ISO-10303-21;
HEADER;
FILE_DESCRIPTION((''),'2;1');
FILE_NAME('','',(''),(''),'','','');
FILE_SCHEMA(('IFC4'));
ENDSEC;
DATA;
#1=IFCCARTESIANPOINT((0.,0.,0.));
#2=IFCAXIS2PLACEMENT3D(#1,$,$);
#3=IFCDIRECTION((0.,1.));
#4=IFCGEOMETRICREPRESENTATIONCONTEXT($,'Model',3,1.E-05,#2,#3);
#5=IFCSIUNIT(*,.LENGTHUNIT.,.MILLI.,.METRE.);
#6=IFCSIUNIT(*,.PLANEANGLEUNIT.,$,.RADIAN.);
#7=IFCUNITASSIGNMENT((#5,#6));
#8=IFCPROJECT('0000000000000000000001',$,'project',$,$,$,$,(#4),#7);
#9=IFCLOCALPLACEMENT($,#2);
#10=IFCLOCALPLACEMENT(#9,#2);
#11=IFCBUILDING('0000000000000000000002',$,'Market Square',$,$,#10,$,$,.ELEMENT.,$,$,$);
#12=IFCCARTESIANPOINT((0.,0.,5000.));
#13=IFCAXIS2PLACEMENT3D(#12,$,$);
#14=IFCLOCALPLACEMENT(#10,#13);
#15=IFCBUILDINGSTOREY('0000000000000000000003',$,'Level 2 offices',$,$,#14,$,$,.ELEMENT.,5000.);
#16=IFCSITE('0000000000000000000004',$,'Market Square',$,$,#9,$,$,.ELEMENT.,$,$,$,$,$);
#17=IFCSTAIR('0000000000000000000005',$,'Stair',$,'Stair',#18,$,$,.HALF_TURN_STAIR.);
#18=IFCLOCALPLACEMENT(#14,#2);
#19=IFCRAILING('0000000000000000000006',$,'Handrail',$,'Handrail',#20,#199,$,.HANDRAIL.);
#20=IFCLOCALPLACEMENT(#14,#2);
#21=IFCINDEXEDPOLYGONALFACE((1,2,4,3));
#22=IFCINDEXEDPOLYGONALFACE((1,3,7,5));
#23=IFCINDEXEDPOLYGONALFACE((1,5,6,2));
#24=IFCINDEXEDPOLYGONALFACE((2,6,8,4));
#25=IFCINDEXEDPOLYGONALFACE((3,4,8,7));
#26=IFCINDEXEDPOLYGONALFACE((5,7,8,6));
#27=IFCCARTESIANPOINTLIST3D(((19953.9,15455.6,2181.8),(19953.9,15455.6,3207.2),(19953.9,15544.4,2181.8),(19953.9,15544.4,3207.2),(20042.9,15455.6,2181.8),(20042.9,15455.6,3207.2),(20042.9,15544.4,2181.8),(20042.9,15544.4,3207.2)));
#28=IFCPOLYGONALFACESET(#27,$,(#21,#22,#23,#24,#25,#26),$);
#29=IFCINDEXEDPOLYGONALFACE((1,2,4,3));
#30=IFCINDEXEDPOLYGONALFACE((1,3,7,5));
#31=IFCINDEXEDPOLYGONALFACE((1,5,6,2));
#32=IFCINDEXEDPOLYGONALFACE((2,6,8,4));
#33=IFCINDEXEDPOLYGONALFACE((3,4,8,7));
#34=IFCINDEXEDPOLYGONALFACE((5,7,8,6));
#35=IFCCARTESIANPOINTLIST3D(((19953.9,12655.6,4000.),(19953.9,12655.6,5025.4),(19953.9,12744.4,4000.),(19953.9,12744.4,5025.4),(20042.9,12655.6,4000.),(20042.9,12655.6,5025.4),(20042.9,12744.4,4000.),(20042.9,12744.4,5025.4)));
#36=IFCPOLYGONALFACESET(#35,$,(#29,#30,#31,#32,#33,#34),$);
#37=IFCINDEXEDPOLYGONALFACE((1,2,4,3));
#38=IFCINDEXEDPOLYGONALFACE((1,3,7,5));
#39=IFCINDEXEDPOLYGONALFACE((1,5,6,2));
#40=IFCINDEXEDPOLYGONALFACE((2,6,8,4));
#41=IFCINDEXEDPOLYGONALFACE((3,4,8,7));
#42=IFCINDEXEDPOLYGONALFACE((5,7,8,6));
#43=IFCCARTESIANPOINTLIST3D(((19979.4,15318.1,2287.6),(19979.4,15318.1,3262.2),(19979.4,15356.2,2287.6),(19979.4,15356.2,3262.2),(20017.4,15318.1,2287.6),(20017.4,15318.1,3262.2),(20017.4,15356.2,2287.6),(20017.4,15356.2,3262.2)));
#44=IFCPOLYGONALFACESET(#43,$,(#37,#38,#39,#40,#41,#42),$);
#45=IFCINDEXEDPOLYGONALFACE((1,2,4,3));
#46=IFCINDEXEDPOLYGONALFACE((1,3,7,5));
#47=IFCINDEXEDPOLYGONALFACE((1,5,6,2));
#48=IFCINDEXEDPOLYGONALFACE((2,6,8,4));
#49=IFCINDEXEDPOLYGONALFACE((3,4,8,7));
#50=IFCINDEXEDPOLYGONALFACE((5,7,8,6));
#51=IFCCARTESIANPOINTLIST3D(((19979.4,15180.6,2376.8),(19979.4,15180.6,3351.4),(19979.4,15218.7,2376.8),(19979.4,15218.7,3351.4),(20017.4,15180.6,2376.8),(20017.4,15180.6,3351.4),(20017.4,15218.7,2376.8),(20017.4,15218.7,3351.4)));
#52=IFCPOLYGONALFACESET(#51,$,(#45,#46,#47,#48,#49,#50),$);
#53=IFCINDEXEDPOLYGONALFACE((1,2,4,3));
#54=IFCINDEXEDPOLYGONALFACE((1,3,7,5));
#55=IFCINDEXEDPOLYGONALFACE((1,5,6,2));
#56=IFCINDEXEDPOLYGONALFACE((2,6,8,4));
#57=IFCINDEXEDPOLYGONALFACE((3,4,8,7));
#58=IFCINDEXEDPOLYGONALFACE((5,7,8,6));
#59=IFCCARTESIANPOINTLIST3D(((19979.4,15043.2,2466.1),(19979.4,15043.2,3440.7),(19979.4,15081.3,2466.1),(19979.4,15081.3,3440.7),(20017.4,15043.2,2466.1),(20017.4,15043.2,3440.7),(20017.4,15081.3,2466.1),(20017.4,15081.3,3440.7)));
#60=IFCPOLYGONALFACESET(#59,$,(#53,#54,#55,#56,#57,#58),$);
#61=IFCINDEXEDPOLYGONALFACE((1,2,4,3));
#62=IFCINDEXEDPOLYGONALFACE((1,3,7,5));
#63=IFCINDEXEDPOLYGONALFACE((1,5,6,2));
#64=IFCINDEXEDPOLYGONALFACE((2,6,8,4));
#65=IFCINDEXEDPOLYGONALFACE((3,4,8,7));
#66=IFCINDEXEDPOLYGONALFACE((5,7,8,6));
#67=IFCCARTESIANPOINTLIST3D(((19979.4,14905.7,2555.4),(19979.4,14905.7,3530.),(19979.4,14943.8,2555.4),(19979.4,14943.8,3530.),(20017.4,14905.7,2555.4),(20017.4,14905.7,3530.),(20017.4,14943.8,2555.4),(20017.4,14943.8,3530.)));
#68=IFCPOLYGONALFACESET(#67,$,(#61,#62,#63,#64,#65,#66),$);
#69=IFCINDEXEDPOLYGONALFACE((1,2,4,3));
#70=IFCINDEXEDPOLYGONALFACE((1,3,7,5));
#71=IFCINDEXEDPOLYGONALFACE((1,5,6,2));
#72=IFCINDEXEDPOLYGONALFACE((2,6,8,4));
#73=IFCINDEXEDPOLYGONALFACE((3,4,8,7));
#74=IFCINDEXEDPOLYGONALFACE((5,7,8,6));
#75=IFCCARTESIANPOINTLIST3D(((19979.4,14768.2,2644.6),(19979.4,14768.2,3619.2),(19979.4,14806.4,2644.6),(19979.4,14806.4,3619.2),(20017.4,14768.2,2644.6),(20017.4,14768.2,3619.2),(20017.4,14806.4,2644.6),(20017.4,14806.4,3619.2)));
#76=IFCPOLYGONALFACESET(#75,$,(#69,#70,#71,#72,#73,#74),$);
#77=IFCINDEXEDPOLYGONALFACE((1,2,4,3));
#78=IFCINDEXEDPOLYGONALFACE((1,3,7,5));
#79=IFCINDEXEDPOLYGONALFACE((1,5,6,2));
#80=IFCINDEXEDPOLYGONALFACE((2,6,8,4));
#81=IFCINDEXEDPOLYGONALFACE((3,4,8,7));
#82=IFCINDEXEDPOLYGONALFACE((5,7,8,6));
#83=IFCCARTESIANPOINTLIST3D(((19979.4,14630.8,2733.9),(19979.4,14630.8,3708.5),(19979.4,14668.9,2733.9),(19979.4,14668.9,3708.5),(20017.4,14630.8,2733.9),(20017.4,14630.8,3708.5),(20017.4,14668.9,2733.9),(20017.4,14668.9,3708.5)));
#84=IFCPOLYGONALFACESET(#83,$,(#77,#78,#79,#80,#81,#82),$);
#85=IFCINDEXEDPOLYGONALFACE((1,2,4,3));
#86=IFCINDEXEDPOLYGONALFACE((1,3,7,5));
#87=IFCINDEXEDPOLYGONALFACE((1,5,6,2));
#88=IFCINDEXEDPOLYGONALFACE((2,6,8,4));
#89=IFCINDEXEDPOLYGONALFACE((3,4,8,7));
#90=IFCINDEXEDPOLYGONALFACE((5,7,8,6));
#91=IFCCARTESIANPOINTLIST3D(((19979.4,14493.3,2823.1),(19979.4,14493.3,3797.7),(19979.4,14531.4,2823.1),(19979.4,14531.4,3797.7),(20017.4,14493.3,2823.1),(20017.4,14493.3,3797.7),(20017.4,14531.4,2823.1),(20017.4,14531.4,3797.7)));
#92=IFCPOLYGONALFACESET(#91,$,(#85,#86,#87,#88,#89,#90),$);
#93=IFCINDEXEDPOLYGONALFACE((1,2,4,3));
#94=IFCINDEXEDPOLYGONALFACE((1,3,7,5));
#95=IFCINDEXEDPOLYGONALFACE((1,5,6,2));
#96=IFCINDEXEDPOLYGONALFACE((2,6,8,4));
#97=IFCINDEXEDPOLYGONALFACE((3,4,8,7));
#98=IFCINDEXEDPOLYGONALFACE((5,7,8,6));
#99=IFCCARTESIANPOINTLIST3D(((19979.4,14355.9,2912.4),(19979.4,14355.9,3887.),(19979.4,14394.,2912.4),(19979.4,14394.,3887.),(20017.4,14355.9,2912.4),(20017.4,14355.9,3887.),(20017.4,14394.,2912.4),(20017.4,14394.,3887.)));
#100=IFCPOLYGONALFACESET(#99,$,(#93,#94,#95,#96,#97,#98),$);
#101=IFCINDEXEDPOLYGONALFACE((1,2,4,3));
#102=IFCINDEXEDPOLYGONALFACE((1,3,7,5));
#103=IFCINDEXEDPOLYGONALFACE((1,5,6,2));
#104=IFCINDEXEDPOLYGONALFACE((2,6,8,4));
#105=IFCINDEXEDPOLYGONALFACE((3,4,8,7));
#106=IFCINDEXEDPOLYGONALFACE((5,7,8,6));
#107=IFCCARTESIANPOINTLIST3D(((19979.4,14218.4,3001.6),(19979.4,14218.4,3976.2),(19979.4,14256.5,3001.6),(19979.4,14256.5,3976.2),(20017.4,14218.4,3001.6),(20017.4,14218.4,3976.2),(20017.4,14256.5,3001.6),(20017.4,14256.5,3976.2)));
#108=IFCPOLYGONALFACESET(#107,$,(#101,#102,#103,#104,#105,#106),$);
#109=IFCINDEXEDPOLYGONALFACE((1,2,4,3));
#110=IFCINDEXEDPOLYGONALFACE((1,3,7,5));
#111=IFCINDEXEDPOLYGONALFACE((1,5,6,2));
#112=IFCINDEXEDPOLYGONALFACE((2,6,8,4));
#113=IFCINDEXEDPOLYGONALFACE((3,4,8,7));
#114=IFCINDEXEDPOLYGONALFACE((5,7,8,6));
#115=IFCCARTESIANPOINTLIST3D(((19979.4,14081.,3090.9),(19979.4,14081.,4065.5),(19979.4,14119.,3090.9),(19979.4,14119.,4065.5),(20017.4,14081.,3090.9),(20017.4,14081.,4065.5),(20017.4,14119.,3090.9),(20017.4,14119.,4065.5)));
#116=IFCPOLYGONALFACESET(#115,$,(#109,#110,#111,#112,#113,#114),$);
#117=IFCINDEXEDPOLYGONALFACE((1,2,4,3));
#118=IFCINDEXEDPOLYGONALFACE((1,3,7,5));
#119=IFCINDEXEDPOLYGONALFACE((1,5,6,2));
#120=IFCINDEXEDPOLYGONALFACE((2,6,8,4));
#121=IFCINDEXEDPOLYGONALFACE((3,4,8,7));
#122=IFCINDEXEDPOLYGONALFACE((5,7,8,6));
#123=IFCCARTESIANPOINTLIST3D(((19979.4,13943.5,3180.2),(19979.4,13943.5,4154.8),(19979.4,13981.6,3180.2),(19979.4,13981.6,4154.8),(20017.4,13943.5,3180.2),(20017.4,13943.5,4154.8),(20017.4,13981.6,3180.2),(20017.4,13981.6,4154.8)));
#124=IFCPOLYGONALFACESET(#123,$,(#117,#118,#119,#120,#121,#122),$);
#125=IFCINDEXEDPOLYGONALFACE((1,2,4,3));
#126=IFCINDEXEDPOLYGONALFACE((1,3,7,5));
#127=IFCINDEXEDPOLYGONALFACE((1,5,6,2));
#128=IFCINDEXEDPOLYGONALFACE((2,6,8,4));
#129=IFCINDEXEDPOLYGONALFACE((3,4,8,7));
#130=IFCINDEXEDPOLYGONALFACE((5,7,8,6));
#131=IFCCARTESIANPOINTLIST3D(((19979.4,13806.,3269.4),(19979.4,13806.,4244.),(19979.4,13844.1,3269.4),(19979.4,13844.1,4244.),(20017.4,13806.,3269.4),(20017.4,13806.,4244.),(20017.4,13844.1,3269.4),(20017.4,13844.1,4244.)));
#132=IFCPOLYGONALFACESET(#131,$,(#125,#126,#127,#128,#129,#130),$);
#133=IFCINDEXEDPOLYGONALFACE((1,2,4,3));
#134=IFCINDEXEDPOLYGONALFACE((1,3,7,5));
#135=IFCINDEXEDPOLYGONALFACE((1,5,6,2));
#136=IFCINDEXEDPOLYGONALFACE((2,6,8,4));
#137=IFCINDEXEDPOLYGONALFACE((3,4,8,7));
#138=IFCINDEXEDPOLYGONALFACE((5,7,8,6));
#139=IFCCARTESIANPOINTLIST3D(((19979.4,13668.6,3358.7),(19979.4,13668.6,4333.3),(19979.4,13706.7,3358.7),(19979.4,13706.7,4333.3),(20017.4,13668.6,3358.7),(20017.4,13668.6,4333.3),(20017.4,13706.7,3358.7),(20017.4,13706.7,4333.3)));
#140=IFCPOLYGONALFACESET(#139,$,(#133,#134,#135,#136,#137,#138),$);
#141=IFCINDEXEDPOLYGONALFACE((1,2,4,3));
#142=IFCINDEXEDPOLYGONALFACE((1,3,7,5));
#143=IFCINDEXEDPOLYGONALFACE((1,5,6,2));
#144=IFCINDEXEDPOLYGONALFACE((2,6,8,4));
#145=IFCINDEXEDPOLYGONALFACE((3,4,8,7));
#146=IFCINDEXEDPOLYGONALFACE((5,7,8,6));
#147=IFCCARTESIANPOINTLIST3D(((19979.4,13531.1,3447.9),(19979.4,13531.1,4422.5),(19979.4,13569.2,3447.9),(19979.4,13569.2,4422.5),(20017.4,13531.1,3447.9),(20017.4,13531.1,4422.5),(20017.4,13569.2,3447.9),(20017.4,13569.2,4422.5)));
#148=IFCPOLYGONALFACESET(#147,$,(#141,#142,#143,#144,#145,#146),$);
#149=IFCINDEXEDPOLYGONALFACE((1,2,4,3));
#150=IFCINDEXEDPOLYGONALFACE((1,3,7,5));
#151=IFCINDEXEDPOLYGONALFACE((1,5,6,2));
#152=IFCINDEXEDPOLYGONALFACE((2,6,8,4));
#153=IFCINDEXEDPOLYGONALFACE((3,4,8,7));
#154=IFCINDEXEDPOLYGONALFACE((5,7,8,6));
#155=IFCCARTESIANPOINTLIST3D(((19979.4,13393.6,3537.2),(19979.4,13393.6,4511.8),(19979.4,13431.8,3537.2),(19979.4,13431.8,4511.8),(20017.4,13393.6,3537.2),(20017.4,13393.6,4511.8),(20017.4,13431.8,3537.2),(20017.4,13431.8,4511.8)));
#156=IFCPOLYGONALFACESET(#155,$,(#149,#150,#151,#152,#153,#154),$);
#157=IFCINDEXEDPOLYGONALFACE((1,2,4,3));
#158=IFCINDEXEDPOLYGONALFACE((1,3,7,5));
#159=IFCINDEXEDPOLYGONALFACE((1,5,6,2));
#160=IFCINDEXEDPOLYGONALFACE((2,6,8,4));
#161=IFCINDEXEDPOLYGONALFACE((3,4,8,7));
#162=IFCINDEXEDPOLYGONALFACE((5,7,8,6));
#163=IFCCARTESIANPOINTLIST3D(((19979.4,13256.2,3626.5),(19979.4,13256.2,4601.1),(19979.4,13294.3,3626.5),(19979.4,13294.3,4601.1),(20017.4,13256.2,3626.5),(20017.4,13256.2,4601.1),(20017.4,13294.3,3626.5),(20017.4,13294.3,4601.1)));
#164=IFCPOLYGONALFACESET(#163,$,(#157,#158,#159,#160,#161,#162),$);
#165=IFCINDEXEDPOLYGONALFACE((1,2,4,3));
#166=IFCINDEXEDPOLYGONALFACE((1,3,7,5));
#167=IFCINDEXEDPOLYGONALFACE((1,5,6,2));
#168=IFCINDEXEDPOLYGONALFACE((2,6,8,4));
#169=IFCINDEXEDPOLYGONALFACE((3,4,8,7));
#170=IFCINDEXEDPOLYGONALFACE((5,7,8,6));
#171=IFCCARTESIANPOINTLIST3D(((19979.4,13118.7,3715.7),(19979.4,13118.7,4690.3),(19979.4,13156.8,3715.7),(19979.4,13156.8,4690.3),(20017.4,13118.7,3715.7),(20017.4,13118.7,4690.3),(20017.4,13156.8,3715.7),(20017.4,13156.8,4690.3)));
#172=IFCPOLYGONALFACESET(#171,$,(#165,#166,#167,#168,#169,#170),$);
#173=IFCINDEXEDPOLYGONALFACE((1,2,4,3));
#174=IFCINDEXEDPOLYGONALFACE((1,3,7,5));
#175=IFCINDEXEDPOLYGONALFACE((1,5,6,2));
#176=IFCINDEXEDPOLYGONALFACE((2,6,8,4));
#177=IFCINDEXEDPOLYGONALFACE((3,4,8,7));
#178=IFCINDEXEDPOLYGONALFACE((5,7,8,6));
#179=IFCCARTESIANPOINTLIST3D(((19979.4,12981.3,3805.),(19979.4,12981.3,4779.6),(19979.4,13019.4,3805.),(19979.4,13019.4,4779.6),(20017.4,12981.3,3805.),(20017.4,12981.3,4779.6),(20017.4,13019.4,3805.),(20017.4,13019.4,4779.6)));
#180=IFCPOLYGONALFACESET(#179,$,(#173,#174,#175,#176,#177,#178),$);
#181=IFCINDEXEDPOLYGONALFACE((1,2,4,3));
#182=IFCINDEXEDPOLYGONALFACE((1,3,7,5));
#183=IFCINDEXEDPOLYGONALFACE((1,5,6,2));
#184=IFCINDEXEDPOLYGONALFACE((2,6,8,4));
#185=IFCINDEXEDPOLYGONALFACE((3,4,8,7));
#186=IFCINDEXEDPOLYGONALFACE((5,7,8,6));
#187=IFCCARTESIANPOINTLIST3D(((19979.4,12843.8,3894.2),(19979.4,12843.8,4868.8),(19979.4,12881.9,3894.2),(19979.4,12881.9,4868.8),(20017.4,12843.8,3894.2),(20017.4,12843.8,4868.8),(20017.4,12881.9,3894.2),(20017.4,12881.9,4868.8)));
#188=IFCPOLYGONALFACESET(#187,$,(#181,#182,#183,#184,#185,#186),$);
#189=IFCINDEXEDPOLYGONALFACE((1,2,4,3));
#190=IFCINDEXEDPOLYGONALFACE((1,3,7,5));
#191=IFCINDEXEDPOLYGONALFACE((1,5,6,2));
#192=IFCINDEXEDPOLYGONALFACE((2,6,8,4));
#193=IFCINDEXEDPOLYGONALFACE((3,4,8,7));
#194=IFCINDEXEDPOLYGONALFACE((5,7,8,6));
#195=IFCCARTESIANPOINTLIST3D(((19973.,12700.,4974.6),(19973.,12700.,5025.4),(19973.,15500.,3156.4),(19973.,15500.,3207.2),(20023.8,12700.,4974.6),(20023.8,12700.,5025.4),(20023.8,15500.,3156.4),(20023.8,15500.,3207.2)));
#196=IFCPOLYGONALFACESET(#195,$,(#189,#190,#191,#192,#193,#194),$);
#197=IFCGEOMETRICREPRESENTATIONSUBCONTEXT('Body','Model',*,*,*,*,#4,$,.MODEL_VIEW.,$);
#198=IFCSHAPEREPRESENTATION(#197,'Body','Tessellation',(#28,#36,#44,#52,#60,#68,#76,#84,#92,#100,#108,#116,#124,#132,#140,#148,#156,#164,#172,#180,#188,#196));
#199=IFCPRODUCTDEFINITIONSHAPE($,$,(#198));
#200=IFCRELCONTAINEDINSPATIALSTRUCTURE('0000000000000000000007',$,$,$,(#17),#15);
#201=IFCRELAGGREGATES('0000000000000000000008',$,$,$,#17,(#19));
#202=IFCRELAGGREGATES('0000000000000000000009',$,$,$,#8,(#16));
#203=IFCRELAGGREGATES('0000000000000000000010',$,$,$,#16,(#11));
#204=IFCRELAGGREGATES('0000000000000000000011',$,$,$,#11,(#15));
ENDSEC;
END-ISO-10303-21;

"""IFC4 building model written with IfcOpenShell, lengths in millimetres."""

from ifc_helpers import new_model, si_unit, direction, frame, origin, origin_with_axes, place, context, subcontext, project, spatial, polyline, outline, extrude, element, aggregate, save


model = new_model("IFC4")

# Units and contexts
model_context = context("Model", 3, precision=1e-05, world=origin(), true_north=direction((0.0, 1.0)))
body_context = subcontext(model_context, "Body", "Model", "MODEL_VIEW")
ifc_project = project(units=[si_unit("LENGTHUNIT", "METRE", prefix="MILLI"), si_unit("PLANEANGLEUNIT", "RADIAN")], contexts=[model_context])

# Site, building, storey
site_placement = place(None, origin())
site = spatial("IfcSite", under=ifc_project, at=site_placement, Name="Market Square", CompositionType="ELEMENT")
building_placement = place(site_placement, origin())
building = spatial("IfcBuilding", under=site, at=building_placement, Name="Market Square", CompositionType="ELEMENT")
storey_placement = place(building_placement, frame((0.0, 0.0, 5000.0)))
storey = spatial("IfcBuildingStorey", under=building, at=storey_placement, Name="Level 2 offices", CompositionType="ELEMENT", Elevation=5000.0)

# Stair, railing
stair_placement = place(storey_placement, origin_with_axes())
stair = element("IfcStair", 1, at=stair_placement, inside=storey, Name="Stair", ObjectType="Stair", PredefinedType="HALF_TURN_STAIR")
railing_1_placement = place(storey_placement, origin_with_axes())
railing_1 = element("IfcRailing", 2, at=railing_1_placement, Name="Handrail", ObjectType="Handrail", PredefinedType="HANDRAIL", context=body_context, shape_type="SweptSolid", body=[
    extrude(outline(polyline([(-44.5, -44.5), (44.5, -44.5), (44.5, 44.5), (-44.5, 44.5), (-44.5, -44.5)])), frame((19998.4, 15500.0, 2181.8), z_axis=(0.0, 0.0, 1.0), x_axis=(1.0, 0.0, 0.0)), (0.0, 0.0, 1.0), 1025.4),
    extrude(outline(polyline([(-44.5, -44.5), (44.5, -44.5), (44.5, 44.5), (-44.5, 44.5), (-44.5, -44.5)])), frame((19998.4, 12700.0, 4000.0), z_axis=(0.0, 0.0, 1.0), x_axis=(1.0, 0.0, 0.0)), (0.0, 0.0, 1.0), 1025.4),
    extrude(outline(polyline([(-19.1, -19.1), (19.1, -19.1), (19.1, 19.1), (-19.1, 19.1), (-19.1, -19.1)])), frame((19998.4, 15337.1, 2287.6), z_axis=(0.0, 0.0, 1.0), x_axis=(1.0, 0.0, 0.0)), (0.0, 0.0, 1.0), 974.6),
    extrude(outline(polyline([(-19.1, -19.1), (19.1, -19.1), (19.1, 19.1), (-19.1, 19.1), (-19.1, -19.1)])), frame((19998.4, 15199.7, 2376.8), z_axis=(0.0, 0.0, 1.0), x_axis=(1.0, 0.0, 0.0)), (0.0, 0.0, 1.0), 974.6),
    extrude(outline(polyline([(-19.1, -19.1), (19.1, -19.1), (19.1, 19.1), (-19.1, 19.1), (-19.1, -19.1)])), frame((19998.4, 15062.2, 2466.1), z_axis=(0.0, 0.0, 1.0), x_axis=(1.0, 0.0, 0.0)), (0.0, 0.0, 1.0), 974.6),
    extrude(outline(polyline([(-19.1, -19.1), (19.1, -19.1), (19.1, 19.1), (-19.1, 19.1), (-19.1, -19.1)])), frame((19998.4, 14924.8, 2555.4), z_axis=(0.0, 0.0, 1.0), x_axis=(1.0, 0.0, 0.0)), (0.0, 0.0, 1.0), 974.6),
    extrude(outline(polyline([(-19.1, -19.1), (19.1, -19.1), (19.1, 19.1), (-19.1, 19.1), (-19.1, -19.1)])), frame((19998.4, 14787.3, 2644.6), z_axis=(0.0, 0.0, 1.0), x_axis=(1.0, 0.0, 0.0)), (0.0, 0.0, 1.0), 974.6),
    extrude(outline(polyline([(-19.1, -19.1), (19.1, -19.1), (19.1, 19.1), (-19.1, 19.1), (-19.1, -19.1)])), frame((19998.4, 14649.8, 2733.9), z_axis=(0.0, 0.0, 1.0), x_axis=(1.0, 0.0, 0.0)), (0.0, 0.0, 1.0), 974.6),
    extrude(outline(polyline([(-19.1, -19.1), (19.1, -19.1), (19.1, 19.1), (-19.1, 19.1), (-19.1, -19.1)])), frame((19998.4, 14512.4, 2823.1), z_axis=(0.0, 0.0, 1.0), x_axis=(1.0, 0.0, 0.0)), (0.0, 0.0, 1.0), 974.6),
    extrude(outline(polyline([(-19.1, -19.1), (19.1, -19.1), (19.1, 19.1), (-19.1, 19.1), (-19.1, -19.1)])), frame((19998.4, 14374.9, 2912.4), z_axis=(0.0, 0.0, 1.0), x_axis=(1.0, 0.0, 0.0)), (0.0, 0.0, 1.0), 974.6),
    extrude(outline(polyline([(-19.1, -19.1), (19.1, -19.1), (19.1, 19.1), (-19.1, 19.1), (-19.1, -19.1)])), frame((19998.4, 14237.5, 3001.6), z_axis=(0.0, 0.0, 1.0), x_axis=(1.0, 0.0, 0.0)), (0.0, 0.0, 1.0), 974.6),
    extrude(outline(polyline([(-19.1, -19.1), (19.1, -19.1), (19.1, 19.1), (-19.1, 19.1), (-19.1, -19.1)])), frame((19998.4, 14100.0, 3090.9), z_axis=(0.0, 0.0, 1.0), x_axis=(1.0, 0.0, 0.0)), (0.0, 0.0, 1.0), 974.6),
    extrude(outline(polyline([(-19.1, -19.1), (19.1, -19.1), (19.1, 19.1), (-19.1, 19.1), (-19.1, -19.1)])), frame((19998.4, 13962.5, 3180.2), z_axis=(0.0, 0.0, 1.0), x_axis=(1.0, 0.0, 0.0)), (0.0, 0.0, 1.0), 974.6),
    extrude(outline(polyline([(-19.1, -19.1), (19.1, -19.1), (19.1, 19.1), (-19.1, 19.1), (-19.1, -19.1)])), frame((19998.4, 13825.1, 3269.4), z_axis=(0.0, 0.0, 1.0), x_axis=(1.0, 0.0, 0.0)), (0.0, 0.0, 1.0), 974.6),
    extrude(outline(polyline([(-19.1, -19.1), (19.1, -19.1), (19.1, 19.1), (-19.1, 19.1), (-19.1, -19.1)])), frame((19998.4, 13687.6, 3358.7), z_axis=(0.0, 0.0, 1.0), x_axis=(1.0, 0.0, 0.0)), (0.0, 0.0, 1.0), 974.6),
    extrude(outline(polyline([(-19.1, -19.1), (19.1, -19.1), (19.1, 19.1), (-19.1, 19.1), (-19.1, -19.1)])), frame((19998.4, 13550.2, 3447.9), z_axis=(0.0, 0.0, 1.0), x_axis=(1.0, 0.0, 0.0)), (0.0, 0.0, 1.0), 974.6),
    extrude(outline(polyline([(-19.1, -19.1), (19.1, -19.1), (19.1, 19.1), (-19.1, 19.1), (-19.1, -19.1)])), frame((19998.4, 13412.7, 3537.2), z_axis=(0.0, 0.0, 1.0), x_axis=(1.0, 0.0, 0.0)), (0.0, 0.0, 1.0), 974.6),
    extrude(outline(polyline([(-19.1, -19.1), (19.1, -19.1), (19.1, 19.1), (-19.1, 19.1), (-19.1, -19.1)])), frame((19998.4, 13275.2, 3626.5), z_axis=(0.0, 0.0, 1.0), x_axis=(1.0, 0.0, 0.0)), (0.0, 0.0, 1.0), 974.6),
    extrude(outline(polyline([(-19.1, -19.1), (19.1, -19.1), (19.1, 19.1), (-19.1, 19.1), (-19.1, -19.1)])), frame((19998.4, 13137.8, 3715.7), z_axis=(0.0, 0.0, 1.0), x_axis=(1.0, 0.0, 0.0)), (0.0, 0.0, 1.0), 974.6),
    extrude(outline(polyline([(-19.1, -19.1), (19.1, -19.1), (19.1, 19.1), (-19.1, 19.1), (-19.1, -19.1)])), frame((19998.4, 13000.3, 3805.0), z_axis=(0.0, 0.0, 1.0), x_axis=(1.0, 0.0, 0.0)), (0.0, 0.0, 1.0), 974.6),
    extrude(outline(polyline([(-19.1, -19.1), (19.1, -19.1), (19.1, 19.1), (-19.1, 19.1), (-19.1, -19.1)])), frame((19998.4, 12862.9, 3894.2), z_axis=(0.0, 0.0, 1.0), x_axis=(1.0, 0.0, 0.0)), (0.0, 0.0, 1.0), 974.6),
    extrude(outline(polyline([(0.0, 0.0), (50.8, 0.0), (50.8, 50.8), (0.0, 50.8), (0.0, 0.0)])), frame((19973.0, 15500.0, 3156.4), z_axis=(0.0, -1.0, 0.0), x_axis=(1.0, 0.0, 0.0)), (0.0, 0.544605, 0.838692), 3338.5),
])
aggregate(stair, [railing_1])

save(model, "model.ifc")
